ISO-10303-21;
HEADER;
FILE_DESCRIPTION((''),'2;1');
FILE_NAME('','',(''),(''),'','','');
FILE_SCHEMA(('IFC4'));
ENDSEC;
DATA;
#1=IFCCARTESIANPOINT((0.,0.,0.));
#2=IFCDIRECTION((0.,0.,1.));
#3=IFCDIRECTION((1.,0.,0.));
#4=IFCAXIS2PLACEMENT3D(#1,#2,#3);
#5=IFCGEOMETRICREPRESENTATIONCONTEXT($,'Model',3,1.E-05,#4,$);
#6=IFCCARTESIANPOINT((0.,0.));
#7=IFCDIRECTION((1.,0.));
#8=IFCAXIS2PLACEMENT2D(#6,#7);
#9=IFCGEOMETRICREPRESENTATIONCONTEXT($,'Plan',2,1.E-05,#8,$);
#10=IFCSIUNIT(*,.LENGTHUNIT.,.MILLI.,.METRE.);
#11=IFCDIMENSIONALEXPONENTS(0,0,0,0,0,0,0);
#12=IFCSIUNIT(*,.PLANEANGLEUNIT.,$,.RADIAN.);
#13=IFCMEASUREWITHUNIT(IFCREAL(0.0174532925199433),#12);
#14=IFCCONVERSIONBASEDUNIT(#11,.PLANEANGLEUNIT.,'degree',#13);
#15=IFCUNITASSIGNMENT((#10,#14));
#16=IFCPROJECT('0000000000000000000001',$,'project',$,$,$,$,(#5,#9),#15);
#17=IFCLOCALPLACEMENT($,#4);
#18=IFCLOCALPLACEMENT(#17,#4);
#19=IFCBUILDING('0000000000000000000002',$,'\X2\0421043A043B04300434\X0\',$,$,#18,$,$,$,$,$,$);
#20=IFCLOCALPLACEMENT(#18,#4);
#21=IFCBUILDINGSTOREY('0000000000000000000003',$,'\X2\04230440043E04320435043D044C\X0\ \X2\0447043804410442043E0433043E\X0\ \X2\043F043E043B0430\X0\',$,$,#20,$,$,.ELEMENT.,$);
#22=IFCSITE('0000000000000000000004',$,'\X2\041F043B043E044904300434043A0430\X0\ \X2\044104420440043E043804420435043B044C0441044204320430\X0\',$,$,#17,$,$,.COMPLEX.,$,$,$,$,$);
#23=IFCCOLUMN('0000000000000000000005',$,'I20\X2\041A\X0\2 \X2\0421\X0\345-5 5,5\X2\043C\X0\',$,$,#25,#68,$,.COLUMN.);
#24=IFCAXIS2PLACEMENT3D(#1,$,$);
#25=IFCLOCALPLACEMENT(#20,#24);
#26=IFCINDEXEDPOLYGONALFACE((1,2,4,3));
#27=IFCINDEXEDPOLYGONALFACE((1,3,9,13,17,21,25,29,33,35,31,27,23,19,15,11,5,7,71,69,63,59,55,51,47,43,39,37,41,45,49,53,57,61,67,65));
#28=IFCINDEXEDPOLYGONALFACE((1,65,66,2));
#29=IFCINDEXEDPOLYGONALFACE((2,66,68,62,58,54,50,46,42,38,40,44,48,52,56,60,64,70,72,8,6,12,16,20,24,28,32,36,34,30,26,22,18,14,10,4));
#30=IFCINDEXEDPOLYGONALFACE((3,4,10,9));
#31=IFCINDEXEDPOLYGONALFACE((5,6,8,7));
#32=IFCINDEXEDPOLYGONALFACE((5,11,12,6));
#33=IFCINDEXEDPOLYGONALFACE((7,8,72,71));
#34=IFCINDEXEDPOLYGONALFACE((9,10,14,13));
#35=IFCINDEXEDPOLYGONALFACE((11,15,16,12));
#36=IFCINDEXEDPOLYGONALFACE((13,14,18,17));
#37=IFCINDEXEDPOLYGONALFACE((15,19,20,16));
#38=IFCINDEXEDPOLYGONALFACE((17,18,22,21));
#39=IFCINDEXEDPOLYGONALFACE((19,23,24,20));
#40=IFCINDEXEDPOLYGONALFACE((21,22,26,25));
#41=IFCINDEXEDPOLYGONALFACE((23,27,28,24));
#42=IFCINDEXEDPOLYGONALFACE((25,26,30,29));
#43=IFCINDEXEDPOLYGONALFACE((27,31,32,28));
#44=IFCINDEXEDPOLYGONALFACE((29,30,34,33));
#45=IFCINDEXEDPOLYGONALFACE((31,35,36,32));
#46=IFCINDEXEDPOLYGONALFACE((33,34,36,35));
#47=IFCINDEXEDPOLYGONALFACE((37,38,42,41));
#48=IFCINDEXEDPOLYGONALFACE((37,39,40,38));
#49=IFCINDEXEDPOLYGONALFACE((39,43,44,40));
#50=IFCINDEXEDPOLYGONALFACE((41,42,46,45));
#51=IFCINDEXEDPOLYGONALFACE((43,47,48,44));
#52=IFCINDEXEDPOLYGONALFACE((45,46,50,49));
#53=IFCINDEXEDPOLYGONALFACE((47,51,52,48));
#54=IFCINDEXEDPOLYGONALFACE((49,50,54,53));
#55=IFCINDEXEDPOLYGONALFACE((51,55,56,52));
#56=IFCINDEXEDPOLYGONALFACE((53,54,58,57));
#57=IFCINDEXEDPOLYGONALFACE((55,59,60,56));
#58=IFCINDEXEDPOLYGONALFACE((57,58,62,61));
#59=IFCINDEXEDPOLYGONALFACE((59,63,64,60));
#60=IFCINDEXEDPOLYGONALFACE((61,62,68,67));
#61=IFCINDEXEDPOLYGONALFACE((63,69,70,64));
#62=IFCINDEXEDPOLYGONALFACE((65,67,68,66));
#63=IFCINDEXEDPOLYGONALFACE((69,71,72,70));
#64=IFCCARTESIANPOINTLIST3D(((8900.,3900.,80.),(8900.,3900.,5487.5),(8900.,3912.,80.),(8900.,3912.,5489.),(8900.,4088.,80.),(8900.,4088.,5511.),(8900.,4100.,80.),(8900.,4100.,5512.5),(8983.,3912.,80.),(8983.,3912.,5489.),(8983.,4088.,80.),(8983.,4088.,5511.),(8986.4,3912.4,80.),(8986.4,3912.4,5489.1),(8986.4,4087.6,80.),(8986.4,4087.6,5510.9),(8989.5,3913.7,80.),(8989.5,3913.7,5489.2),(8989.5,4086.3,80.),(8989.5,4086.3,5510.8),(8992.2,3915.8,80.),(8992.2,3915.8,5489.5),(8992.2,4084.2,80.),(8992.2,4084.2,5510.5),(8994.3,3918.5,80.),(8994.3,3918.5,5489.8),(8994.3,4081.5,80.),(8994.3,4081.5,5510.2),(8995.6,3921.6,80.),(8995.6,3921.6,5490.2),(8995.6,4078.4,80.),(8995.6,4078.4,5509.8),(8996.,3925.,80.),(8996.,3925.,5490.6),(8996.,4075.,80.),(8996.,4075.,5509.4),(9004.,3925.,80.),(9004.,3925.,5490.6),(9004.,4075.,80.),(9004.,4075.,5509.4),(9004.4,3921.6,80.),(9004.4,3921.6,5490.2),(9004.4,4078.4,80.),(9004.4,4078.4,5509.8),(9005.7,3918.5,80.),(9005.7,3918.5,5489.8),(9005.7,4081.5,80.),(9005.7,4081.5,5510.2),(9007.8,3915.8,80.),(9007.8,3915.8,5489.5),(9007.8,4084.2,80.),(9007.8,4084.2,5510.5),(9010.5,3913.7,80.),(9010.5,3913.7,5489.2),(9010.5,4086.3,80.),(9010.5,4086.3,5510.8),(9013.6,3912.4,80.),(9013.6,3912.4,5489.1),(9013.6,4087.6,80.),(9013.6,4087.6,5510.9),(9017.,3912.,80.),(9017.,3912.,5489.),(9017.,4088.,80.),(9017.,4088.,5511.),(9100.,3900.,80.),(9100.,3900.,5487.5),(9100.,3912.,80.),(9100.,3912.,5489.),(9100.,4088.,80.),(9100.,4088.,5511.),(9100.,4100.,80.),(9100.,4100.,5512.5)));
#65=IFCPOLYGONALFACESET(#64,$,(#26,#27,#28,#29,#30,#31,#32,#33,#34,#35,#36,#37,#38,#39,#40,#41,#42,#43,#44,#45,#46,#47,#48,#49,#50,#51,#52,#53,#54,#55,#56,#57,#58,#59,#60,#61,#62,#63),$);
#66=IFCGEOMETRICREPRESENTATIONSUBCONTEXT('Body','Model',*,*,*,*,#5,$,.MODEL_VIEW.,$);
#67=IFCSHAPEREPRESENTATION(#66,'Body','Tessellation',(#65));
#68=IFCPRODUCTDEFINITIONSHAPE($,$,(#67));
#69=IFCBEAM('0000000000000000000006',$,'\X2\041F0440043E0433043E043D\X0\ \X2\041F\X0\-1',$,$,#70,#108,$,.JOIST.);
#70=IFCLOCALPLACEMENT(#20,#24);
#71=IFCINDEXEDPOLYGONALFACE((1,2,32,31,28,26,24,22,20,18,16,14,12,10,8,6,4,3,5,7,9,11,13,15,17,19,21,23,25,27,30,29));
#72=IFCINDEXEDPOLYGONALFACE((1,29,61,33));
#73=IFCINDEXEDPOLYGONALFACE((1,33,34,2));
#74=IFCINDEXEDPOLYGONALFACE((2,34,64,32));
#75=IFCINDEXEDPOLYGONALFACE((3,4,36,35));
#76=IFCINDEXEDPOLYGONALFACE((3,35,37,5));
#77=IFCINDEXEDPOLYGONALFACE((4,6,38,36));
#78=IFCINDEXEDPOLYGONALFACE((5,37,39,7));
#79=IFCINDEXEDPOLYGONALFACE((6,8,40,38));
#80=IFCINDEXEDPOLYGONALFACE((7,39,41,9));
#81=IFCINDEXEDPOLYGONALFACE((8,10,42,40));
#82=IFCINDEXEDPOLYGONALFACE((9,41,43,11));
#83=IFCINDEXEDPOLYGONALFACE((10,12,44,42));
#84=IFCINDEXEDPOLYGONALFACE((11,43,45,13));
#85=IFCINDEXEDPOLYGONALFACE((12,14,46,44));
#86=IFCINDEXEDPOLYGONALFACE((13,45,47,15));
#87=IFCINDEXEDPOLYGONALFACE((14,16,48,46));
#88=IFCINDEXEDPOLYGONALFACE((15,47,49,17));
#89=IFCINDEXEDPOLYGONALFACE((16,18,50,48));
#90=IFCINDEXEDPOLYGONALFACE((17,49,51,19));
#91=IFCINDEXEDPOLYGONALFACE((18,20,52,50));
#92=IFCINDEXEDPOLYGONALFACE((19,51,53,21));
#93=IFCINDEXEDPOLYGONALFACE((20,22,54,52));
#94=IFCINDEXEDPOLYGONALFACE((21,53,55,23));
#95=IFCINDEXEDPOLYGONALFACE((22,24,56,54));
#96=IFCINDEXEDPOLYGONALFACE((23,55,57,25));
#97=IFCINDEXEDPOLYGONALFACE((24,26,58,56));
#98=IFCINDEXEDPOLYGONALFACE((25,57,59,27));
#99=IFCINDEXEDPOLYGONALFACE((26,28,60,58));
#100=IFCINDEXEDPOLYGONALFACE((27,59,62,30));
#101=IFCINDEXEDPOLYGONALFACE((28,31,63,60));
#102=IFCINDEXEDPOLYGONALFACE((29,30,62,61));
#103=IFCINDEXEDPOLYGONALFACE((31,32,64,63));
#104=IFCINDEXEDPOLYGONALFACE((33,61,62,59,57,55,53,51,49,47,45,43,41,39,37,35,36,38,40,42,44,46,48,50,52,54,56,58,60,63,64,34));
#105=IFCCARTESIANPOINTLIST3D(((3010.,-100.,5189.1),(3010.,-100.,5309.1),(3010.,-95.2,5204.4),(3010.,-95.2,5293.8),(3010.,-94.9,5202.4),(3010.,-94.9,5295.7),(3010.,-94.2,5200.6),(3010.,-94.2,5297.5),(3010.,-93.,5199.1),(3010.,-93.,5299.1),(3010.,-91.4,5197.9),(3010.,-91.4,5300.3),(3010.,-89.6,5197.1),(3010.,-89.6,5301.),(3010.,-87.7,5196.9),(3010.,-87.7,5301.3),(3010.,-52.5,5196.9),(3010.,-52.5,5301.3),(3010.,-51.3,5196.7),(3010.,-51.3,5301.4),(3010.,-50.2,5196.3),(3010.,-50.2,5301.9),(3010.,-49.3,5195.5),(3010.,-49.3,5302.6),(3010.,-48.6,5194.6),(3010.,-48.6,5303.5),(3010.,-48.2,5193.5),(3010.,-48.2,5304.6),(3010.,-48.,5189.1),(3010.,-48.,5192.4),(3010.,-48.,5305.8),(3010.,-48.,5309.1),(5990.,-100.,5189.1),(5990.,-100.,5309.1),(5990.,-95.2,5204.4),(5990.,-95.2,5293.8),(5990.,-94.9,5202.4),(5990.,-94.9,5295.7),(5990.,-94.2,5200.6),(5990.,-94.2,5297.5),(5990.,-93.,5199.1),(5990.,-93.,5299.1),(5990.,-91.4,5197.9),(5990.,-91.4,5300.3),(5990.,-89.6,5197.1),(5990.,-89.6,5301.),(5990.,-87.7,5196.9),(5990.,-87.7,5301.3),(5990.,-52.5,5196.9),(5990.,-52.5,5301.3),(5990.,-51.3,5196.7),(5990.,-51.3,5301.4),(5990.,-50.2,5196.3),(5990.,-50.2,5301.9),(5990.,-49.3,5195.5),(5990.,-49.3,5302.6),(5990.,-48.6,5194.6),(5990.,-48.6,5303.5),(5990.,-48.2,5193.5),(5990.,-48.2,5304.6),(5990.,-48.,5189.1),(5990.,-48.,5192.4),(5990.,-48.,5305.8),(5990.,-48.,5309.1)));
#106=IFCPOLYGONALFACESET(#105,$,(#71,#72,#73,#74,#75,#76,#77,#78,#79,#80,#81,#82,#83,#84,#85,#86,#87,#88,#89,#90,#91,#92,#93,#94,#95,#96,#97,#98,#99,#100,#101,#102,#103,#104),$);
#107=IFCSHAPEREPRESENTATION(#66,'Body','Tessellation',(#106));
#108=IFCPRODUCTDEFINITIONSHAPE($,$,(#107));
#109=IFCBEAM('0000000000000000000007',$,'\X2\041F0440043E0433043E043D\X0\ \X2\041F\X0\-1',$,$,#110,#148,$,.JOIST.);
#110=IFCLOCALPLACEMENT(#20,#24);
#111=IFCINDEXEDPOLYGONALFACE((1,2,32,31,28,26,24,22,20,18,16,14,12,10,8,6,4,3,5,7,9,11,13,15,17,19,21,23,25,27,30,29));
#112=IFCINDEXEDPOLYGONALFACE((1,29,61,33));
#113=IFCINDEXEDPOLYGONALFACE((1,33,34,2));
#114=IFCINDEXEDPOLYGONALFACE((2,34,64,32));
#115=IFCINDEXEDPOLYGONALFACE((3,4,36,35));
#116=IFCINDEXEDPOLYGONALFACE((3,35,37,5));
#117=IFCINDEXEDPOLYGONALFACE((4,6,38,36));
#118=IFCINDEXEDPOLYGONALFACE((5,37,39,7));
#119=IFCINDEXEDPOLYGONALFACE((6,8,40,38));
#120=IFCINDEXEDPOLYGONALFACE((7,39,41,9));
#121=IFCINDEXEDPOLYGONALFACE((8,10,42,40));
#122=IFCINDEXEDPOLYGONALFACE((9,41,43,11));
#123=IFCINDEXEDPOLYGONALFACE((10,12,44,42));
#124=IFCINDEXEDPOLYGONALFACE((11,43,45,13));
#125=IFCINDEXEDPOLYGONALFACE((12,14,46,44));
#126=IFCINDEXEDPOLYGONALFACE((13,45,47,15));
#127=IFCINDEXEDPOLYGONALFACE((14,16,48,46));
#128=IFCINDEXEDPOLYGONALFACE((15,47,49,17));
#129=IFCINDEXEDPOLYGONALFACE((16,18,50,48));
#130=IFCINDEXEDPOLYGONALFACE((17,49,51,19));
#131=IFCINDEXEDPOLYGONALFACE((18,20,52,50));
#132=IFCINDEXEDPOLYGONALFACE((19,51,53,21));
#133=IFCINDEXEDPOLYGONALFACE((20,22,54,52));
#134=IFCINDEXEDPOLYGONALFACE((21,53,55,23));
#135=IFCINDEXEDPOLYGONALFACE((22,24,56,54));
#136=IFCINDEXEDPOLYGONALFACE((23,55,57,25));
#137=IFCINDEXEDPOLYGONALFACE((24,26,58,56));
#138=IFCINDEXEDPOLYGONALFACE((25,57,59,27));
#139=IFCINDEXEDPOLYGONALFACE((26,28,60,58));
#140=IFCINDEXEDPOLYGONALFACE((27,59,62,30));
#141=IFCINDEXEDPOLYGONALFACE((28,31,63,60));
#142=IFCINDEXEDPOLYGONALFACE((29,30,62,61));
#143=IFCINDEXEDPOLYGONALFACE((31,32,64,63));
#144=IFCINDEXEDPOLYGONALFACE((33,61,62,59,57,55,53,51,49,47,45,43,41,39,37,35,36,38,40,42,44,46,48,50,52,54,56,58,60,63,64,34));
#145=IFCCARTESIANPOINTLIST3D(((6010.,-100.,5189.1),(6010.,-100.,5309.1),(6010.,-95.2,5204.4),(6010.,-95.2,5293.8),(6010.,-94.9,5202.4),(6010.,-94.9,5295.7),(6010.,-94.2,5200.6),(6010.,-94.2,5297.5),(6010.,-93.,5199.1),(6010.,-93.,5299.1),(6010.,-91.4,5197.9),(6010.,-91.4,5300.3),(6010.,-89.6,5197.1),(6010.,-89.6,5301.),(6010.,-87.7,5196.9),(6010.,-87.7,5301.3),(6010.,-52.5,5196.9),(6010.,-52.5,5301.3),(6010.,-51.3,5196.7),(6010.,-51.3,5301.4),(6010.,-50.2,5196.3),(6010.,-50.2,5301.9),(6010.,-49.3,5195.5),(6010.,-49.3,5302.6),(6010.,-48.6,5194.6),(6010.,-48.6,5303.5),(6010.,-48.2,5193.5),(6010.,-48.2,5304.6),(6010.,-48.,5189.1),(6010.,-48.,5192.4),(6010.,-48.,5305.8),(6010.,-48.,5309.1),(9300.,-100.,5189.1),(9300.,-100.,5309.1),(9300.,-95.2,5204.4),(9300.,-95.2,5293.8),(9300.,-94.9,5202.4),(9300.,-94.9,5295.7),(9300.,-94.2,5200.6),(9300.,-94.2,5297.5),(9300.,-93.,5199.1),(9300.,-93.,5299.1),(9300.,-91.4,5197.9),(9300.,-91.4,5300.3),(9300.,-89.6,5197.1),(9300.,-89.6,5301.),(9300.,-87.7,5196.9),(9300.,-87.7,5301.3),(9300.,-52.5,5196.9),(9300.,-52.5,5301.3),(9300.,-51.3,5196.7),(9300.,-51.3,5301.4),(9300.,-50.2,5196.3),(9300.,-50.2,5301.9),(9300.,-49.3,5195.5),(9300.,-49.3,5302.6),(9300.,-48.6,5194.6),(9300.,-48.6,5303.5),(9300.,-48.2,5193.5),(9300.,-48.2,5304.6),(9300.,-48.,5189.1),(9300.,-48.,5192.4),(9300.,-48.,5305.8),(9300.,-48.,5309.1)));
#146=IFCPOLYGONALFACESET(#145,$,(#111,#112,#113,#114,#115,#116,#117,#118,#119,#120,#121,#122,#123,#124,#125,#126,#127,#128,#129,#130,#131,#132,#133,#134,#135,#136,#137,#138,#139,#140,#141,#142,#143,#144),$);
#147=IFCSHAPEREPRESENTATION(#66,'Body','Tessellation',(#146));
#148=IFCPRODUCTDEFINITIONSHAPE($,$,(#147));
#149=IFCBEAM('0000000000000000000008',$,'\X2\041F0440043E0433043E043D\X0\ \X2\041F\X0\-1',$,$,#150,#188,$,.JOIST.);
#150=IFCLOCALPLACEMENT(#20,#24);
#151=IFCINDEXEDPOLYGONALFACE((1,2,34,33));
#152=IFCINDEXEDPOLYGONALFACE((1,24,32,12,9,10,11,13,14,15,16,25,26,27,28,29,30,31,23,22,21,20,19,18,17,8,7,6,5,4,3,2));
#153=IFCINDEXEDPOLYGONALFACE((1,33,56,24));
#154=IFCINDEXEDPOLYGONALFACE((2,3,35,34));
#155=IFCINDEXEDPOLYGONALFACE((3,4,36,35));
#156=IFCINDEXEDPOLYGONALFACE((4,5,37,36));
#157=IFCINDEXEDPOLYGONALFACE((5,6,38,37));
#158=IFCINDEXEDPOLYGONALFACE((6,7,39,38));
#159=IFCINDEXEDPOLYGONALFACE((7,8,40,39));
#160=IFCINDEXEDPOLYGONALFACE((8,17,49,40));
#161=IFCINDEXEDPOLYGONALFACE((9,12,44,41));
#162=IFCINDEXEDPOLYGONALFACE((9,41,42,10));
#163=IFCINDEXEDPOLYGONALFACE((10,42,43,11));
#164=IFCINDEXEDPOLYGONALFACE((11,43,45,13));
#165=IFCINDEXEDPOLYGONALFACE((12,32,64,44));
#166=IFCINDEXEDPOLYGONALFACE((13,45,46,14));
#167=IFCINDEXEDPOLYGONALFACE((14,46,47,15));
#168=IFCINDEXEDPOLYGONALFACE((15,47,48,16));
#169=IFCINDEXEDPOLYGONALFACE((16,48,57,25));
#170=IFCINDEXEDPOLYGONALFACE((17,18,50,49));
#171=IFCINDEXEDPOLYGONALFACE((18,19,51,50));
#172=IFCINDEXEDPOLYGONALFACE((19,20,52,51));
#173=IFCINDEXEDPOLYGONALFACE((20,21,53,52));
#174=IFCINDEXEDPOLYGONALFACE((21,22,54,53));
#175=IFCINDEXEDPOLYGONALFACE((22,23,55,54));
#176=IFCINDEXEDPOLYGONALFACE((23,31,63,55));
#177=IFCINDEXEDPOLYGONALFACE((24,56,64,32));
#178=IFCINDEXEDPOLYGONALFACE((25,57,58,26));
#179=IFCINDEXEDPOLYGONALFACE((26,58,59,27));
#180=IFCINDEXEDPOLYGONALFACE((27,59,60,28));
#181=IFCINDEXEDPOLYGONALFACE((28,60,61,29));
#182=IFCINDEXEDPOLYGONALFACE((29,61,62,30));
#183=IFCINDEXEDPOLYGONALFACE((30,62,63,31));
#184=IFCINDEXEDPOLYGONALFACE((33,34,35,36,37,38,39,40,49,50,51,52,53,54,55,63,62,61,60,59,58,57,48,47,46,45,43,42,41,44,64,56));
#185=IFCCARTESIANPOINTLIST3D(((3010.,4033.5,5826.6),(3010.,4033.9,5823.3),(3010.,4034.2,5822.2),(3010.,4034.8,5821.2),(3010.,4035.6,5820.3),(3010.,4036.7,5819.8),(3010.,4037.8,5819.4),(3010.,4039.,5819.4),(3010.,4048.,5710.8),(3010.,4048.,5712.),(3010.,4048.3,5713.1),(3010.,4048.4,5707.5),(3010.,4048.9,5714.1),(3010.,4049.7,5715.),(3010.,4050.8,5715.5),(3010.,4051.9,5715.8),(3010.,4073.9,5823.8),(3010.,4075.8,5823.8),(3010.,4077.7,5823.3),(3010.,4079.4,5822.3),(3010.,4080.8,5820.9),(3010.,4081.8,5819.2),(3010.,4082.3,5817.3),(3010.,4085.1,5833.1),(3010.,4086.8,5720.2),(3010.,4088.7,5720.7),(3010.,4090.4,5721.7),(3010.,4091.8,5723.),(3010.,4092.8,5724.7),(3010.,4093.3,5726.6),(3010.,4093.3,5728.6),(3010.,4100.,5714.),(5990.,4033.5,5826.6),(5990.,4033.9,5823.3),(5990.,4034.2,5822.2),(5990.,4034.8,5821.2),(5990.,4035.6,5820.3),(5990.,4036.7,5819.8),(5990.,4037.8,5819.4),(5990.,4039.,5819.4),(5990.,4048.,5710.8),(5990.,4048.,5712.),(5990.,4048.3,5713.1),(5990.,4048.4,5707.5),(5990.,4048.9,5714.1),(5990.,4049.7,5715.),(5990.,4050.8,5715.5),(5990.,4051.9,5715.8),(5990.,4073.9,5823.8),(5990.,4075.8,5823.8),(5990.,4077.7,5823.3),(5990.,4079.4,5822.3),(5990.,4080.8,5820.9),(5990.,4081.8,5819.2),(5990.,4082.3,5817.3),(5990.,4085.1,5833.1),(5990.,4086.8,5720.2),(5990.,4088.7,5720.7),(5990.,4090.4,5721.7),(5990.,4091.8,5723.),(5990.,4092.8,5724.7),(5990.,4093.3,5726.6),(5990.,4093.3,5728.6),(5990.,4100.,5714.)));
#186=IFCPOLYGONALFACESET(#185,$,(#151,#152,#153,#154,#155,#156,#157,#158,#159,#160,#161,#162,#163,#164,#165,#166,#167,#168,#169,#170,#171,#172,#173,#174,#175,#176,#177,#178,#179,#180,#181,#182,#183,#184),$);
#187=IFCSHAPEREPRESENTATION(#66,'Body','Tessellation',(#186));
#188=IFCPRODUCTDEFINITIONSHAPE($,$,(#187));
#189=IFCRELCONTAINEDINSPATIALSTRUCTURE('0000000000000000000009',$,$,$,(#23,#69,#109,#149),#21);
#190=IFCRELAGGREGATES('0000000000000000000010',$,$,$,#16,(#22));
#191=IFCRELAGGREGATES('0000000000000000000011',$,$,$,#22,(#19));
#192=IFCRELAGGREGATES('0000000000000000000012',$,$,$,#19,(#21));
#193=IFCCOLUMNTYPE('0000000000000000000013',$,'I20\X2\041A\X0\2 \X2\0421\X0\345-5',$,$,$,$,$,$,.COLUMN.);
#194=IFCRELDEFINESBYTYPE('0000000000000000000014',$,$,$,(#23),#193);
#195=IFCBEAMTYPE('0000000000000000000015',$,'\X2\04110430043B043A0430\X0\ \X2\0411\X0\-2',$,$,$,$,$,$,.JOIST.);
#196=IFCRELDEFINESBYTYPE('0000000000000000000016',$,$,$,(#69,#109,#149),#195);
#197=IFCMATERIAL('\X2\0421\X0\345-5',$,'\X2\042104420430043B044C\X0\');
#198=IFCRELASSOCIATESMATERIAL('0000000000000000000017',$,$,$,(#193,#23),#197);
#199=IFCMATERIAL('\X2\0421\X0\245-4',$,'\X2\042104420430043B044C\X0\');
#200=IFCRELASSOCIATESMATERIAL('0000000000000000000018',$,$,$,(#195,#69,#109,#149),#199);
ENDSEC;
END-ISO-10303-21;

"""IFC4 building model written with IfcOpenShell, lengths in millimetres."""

from ifc_helpers import new_model, entity, si_unit, converted_unit, frame, origin_with_axes, origin_2d_with_axis, place, context, subcontext, project, spatial, i_section, u_section, extrude, boolean, clip, halfspace, material, material_profile, profile_set, profile_usage, type_object, element, save


model = new_model("IFC4")

# Units and contexts
model_context = context("Model", 3, precision=1e-05, world=origin_with_axes())
plan_context = context("Plan", 2, precision=1e-05, world=origin_2d_with_axis())
body_context = subcontext(model_context, "Body", "Model", "MODEL_VIEW")
ifc_project = project(units=[si_unit("LENGTHUNIT", "METRE", prefix="MILLI"), converted_unit("PLANEANGLEUNIT", "degree", entity("IfcReal", 0.0174532925199433), si_unit("PLANEANGLEUNIT", "RADIAN"), dimensions=[0, 0, 0, 0, 0, 0, 0])], contexts=[model_context, plan_context])

# Site, building, storey
site_placement = place(None, origin_with_axes())
site = spatial("IfcSite", under=ifc_project, at=site_placement, Name="Площадка строительства", CompositionType="COMPLEX")
building_placement = place(site_placement, origin_with_axes())
building = spatial("IfcBuilding", under=site, at=building_placement, Name="Склад")
storey_placement = place(building_placement, origin_with_axes())
storey = spatial("IfcBuildingStorey", under=building, at=storey_placement, Name="Уровень чистого пола", CompositionType="ELEMENT")

# Column
ifc_material_1 = material(Name="С345-5", Category="Сталь")
ifc_material_profile_1 = material_profile(ifc_material_1, i_section(OverallWidth=200.0, OverallDepth=200.0, WebThickness=8.0, FlangeThickness=12.0, FilletRadius=13.0, FlangeEdgeRadius=0.0, FlangeSlope=0.0))
ifc_profile_set_1 = profile_set([ifc_material_profile_1], Name="I20К2_С345-5")
column_type = type_object("IfcColumnType", Name="I20К2 С345-5", PredefinedType="COLUMN", material=ifc_profile_set_1)
ifc_profile_usage_1 = profile_usage(ifc_profile_set_1, cardinal=5)
column_1_placement = place(storey_placement, frame((9000.0, 4000.0, 0.0), z_axis=(0.0, 0.0, 1.0), x_axis=(1.0, 0.0, 0.0)))
element("IfcColumn", 1, at=column_1_placement, inside=storey, type_object=column_type, material=ifc_profile_usage_1, Name="I20К2 С345-5 5,5м", PredefinedType="COLUMN", context=body_context, shape_type="Clipping", body=[
    boolean("DIFFERENCE", clip(extrude(i_section(OverallWidth=200.0, OverallDepth=200.0, WebThickness=8.0, FlangeThickness=12.0, FilletRadius=13.0, FlangeEdgeRadius=0.0, FlangeSlope=0.0), origin_with_axes(), (0.0, 0.0, 1.0), 5700.0), halfspace(frame((0.0, -4298.5, 4962.7), z_axis=(0.0, -0.124035, 0.992278), x_axis=(0.0, 0.992278, 0.124035)), False)), halfspace(frame((0.0, 0.0, 80.0), z_axis=(0.0, 0.0, -1.0), x_axis=(1.0, 0.0, 0.0)), False)),
])

# Beams
ifc_material_2 = material(Name="С245-4", Category="Сталь")
ifc_material_profile_2 = material_profile(ifc_material_2, u_section(Depth=120.0, FlangeWidth=52.0, WebThickness=4.8, FlangeThickness=7.8, FilletRadius=7.5, EdgeRadius=4.5, FlangeSlope=0.0))
ifc_profile_set_2 = profile_set([ifc_material_profile_2], Name="U12P_S245-4")
ifc_profile_usage_2 = profile_usage(ifc_profile_set_2, cardinal=3)
beam_type_1 = type_object("IfcBeamType", Name="Балка Б-2", PredefinedType="JOIST", material=ifc_profile_set_2)
beam_1_placement = place(storey_placement, frame((3010.0, -100.0, 5189.1), z_axis=(1.0, 0.0, 0.0), x_axis=(0.0, 1.0, 0.0)))
element("IfcBeam", 2, at=beam_1_placement, inside=storey, type_object=beam_type_1, material=ifc_profile_usage_2, Name="Прогон П-1", PredefinedType="JOIST", context=body_context, shape_type="SweptSolid", body=[
    extrude(u_section(Depth=120.0, FlangeWidth=52.0, WebThickness=4.8, FlangeThickness=7.8, FilletRadius=7.5, EdgeRadius=4.5, FlangeSlope=0.0), frame((26.0, 60.0, 0.0), z_axis=(0.0, 0.0, 1.0), x_axis=(1.0, 0.0, 0.0)), (0.0, 0.0, 1.0), 2980.0),
])
ifc_profile_usage_3 = profile_usage(ifc_profile_set_2, cardinal=3)
beam_2_placement = place(storey_placement, frame((6010.0, -100.0, 5189.1), z_axis=(1.0, 0.0, 0.0), x_axis=(0.0, 1.0, 0.0)))
element("IfcBeam", 3, at=beam_2_placement, inside=storey, type_object=beam_type_1, material=ifc_profile_usage_3, Name="Прогон П-1", PredefinedType="JOIST", context=body_context, shape_type="SweptSolid", body=[
    extrude(u_section(Depth=120.0, FlangeWidth=52.0, WebThickness=4.8, FlangeThickness=7.8, FilletRadius=7.5, EdgeRadius=4.5, FlangeSlope=0.0), frame((26.0, 60.0, 0.0), z_axis=(0.0, 0.0, 1.0), x_axis=(1.0, 0.0, 0.0)), (0.0, 0.0, 1.0), 3290.0),
])
ifc_profile_usage_4 = profile_usage(ifc_profile_set_2, cardinal=3)
beam_3_placement = place(storey_placement, frame((5990.0, 4100.0, 5714.0), z_axis=(-1.0, 0.0, 0.0), x_axis=(0.0, -0.99228, -0.12402)))
element("IfcBeam", 4, at=beam_3_placement, inside=storey, type_object=beam_type_1, material=ifc_profile_usage_4, Name="Прогон П-1", PredefinedType="JOIST", context=body_context, shape_type="SweptSolid", body=[
    extrude(u_section(Depth=120.0, FlangeWidth=52.0, WebThickness=4.8, FlangeThickness=7.8, FilletRadius=7.5, EdgeRadius=4.5, FlangeSlope=0.0), frame((26.0, 60.0, 0.0), z_axis=(0.0, 0.0, 1.0), x_axis=(1.0, 0.0, 0.0)), (0.0, 0.0, 1.0), 2980.0),
])

save(model, "model.ifc")
